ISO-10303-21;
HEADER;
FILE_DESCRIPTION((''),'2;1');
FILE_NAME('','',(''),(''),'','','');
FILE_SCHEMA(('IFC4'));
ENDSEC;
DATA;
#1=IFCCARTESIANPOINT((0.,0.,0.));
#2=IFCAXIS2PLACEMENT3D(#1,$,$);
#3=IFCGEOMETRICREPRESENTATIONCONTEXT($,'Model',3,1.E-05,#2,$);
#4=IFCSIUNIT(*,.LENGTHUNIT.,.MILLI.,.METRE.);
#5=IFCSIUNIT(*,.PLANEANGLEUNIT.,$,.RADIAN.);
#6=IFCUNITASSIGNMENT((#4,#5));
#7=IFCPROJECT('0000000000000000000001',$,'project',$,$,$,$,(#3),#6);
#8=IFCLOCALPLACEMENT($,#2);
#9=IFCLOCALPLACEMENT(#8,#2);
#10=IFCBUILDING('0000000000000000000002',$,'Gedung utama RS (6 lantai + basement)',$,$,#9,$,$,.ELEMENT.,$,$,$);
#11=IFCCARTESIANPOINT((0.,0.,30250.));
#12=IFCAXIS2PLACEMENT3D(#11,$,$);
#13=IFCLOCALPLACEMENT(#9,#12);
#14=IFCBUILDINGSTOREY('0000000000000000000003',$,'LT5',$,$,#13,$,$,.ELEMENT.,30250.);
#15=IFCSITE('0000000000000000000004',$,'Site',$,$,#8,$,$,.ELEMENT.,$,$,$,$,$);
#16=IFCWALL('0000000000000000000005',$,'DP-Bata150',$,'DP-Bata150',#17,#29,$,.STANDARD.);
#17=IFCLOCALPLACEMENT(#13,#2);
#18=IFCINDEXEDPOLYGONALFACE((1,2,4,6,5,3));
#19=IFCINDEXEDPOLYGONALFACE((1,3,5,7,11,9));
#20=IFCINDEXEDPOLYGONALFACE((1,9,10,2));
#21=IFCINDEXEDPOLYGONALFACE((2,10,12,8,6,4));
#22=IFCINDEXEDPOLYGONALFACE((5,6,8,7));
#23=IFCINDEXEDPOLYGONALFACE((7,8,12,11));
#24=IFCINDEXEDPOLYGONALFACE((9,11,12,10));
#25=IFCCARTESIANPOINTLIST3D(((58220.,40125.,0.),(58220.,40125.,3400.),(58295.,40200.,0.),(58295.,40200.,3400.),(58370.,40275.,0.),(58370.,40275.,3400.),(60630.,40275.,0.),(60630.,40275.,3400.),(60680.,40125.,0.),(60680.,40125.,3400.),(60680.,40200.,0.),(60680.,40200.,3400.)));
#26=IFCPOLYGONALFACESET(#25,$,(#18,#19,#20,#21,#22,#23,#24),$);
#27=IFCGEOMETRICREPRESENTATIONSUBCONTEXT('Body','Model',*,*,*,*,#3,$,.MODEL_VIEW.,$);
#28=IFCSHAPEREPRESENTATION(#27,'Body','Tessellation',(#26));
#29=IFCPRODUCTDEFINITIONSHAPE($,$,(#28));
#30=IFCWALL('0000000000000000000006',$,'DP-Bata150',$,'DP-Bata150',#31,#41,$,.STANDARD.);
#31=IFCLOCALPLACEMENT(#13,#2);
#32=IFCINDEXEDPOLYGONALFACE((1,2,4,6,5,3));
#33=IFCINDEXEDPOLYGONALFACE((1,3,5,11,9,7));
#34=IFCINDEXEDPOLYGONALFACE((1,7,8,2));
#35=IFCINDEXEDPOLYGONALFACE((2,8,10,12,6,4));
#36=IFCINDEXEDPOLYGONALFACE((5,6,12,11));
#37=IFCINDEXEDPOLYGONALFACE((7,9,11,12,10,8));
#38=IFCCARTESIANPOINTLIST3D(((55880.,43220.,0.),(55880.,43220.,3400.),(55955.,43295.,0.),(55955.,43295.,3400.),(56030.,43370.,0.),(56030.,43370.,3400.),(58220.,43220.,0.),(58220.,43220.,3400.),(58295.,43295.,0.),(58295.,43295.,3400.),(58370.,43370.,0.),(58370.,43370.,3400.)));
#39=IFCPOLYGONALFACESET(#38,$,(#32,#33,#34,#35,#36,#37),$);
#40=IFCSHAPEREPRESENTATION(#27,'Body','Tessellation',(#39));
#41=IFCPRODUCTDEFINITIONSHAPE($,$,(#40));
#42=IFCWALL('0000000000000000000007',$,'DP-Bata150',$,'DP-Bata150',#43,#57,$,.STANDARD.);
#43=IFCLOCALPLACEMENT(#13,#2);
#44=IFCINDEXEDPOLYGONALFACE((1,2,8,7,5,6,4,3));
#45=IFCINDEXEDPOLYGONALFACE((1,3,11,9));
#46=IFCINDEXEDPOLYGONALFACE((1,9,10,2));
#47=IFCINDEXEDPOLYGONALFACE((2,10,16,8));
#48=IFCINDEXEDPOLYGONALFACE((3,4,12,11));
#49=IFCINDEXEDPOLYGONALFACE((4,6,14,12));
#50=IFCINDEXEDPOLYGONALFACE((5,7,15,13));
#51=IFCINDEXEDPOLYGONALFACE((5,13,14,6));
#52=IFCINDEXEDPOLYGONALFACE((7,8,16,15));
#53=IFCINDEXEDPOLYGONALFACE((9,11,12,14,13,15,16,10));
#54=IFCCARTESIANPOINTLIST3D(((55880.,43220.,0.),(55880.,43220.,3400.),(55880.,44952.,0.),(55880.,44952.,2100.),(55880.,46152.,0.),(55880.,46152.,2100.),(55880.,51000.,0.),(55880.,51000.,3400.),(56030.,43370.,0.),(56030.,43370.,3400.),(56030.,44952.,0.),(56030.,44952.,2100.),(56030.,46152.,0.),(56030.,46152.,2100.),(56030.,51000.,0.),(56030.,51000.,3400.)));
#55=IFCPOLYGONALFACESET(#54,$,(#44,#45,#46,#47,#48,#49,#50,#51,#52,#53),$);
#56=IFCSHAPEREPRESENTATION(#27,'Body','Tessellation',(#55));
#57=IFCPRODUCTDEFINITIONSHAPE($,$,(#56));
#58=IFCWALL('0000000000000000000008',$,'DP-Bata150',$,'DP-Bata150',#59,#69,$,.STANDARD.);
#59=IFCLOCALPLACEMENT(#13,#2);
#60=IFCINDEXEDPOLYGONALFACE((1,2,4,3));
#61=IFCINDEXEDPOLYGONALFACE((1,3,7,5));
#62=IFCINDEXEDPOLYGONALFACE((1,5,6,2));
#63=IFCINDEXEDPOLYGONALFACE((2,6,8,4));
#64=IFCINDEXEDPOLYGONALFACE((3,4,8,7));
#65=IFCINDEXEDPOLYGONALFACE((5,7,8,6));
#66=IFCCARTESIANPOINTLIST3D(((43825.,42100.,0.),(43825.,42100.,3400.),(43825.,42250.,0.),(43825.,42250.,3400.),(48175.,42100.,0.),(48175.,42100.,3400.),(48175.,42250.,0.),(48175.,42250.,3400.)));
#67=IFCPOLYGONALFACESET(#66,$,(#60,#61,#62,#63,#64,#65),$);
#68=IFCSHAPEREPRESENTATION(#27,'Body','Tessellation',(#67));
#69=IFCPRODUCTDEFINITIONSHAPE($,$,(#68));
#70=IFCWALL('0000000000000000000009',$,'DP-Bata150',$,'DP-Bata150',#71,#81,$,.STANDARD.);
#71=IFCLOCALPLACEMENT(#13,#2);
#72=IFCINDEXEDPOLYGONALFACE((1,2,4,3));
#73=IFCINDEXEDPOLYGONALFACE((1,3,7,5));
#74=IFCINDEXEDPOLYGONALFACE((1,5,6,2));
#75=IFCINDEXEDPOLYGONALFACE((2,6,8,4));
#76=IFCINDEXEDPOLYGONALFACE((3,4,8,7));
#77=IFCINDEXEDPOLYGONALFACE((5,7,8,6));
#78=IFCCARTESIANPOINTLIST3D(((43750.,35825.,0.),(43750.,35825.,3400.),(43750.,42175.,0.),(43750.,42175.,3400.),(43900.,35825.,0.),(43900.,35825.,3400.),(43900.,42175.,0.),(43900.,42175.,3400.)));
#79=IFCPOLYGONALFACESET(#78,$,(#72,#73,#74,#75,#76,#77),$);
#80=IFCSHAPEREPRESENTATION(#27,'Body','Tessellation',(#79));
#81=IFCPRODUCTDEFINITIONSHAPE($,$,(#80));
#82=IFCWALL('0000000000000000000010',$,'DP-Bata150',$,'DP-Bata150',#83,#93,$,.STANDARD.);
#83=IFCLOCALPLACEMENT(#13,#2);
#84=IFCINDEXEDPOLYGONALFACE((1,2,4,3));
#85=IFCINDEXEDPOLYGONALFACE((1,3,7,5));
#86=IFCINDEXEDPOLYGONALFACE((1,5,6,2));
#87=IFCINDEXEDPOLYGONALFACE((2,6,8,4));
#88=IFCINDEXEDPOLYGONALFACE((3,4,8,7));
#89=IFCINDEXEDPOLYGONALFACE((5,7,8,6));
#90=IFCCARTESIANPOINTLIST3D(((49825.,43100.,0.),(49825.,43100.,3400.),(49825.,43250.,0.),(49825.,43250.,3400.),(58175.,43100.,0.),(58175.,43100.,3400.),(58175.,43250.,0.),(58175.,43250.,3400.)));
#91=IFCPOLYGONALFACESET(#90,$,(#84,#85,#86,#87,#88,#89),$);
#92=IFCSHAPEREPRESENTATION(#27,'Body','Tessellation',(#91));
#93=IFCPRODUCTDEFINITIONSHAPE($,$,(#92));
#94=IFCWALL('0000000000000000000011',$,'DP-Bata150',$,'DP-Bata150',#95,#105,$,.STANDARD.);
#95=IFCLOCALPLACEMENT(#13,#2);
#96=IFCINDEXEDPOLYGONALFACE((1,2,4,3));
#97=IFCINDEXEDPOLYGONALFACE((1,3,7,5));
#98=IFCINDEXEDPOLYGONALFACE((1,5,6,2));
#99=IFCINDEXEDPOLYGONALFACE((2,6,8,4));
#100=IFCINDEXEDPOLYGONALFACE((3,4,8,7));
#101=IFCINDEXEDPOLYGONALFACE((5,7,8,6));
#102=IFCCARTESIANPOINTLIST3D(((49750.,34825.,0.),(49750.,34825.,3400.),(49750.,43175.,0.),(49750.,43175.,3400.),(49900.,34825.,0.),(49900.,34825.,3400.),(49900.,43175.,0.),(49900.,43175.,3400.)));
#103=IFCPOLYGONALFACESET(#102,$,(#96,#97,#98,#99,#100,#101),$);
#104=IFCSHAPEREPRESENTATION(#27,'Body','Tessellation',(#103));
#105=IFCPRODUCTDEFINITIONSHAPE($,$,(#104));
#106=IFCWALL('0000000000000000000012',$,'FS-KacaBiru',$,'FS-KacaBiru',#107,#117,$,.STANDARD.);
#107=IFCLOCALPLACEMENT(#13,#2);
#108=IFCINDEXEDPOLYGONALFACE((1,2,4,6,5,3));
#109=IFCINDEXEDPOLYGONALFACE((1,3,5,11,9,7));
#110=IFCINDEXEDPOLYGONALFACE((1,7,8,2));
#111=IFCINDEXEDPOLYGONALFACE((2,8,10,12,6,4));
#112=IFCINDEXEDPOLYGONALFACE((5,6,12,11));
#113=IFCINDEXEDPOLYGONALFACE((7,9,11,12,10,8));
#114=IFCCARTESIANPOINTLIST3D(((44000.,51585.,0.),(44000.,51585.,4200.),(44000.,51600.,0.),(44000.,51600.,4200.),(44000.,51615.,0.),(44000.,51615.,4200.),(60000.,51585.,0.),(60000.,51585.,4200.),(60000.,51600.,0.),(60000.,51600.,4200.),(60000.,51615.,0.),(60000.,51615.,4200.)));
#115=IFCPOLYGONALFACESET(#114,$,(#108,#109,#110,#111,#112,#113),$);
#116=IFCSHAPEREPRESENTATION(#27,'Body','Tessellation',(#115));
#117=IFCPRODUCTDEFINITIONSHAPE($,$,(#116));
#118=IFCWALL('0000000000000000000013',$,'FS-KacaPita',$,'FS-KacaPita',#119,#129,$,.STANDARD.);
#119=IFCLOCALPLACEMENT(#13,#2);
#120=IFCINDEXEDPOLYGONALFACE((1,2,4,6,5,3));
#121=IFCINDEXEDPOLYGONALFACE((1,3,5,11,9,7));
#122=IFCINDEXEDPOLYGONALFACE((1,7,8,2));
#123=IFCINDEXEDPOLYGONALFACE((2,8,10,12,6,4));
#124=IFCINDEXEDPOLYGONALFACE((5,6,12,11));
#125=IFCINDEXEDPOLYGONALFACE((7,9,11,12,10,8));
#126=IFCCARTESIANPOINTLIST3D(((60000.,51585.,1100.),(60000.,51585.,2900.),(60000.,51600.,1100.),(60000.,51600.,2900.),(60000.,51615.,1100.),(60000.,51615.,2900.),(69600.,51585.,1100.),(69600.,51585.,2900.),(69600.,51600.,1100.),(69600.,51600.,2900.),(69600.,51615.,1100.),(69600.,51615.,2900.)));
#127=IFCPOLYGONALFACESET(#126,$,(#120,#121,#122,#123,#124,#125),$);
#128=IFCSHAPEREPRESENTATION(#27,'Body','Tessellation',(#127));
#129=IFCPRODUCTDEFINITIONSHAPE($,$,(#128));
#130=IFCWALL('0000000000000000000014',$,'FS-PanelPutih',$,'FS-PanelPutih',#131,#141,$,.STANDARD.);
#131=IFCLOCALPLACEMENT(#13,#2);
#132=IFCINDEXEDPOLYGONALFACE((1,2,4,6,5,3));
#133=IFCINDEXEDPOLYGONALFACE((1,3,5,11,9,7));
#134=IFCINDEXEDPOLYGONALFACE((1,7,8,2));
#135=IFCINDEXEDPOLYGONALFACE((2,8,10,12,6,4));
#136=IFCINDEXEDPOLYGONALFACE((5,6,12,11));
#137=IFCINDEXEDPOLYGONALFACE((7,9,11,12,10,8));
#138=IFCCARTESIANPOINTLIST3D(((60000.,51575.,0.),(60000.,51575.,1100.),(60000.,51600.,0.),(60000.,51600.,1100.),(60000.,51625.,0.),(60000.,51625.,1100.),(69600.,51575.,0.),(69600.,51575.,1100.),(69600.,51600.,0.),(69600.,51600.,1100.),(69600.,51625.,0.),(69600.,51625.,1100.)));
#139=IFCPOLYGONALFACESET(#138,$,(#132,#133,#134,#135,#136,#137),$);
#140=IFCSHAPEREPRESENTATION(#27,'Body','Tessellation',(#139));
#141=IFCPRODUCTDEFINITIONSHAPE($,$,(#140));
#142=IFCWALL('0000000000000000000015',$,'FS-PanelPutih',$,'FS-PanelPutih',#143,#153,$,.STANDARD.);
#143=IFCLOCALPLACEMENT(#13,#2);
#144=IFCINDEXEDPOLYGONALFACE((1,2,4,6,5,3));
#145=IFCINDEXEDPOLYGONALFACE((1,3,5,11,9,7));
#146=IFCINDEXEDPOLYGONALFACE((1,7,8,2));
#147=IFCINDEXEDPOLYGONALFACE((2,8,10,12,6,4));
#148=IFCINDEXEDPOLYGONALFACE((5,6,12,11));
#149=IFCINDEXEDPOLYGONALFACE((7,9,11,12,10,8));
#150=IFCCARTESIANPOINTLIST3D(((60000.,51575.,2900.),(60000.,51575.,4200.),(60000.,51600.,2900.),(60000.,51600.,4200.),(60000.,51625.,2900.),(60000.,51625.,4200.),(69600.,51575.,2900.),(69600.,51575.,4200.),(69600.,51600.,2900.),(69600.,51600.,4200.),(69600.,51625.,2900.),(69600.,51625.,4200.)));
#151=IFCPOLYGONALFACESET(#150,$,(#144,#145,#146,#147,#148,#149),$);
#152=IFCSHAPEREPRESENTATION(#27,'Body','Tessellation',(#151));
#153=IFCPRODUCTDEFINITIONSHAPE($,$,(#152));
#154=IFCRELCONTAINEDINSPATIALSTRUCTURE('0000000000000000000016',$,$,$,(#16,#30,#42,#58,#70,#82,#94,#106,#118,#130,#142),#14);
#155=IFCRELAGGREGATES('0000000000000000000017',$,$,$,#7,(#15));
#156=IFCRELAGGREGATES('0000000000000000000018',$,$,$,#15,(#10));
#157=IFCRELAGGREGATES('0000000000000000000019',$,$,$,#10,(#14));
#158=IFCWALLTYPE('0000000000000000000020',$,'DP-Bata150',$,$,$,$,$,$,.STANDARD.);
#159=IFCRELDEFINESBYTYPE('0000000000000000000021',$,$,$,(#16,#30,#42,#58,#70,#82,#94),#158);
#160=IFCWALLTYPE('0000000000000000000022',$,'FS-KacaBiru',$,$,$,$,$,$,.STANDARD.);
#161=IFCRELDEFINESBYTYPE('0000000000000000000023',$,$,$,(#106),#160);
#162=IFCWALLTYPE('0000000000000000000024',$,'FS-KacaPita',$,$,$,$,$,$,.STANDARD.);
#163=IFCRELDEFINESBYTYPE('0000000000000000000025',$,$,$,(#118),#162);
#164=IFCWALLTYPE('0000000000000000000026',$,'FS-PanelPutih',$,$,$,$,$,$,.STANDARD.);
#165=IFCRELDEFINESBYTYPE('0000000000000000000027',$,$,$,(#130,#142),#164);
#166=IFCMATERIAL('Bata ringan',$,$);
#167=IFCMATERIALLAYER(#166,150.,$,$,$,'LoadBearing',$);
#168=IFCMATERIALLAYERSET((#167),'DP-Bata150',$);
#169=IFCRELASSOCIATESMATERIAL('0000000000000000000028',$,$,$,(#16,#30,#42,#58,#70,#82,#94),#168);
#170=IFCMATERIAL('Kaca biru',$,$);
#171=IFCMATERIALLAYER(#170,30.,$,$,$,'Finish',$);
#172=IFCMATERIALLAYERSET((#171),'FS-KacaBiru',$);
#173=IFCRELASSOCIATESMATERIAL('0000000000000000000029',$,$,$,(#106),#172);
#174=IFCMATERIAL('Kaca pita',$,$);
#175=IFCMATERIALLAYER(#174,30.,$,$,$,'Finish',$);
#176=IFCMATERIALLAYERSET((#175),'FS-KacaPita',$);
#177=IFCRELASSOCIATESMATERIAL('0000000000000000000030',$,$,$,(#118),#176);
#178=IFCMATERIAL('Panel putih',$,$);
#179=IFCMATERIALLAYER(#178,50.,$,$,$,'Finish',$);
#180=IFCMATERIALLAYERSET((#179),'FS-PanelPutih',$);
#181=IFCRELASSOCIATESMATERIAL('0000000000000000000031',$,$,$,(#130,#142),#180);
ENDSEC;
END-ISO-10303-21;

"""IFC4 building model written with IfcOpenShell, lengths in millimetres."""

from ifc_helpers import new_model, si_unit, frame, frame_2d, origin, place, context, subcontext, project, spatial, polyline, rectangle, outline, extrude, material, layer, layer_set, layer_usage, type_object, element, save


model = new_model("IFC4")

# Units and contexts
model_context = context("Model", 3, precision=1e-05, world=origin())
body_context = subcontext(model_context, "Body", "Model", "MODEL_VIEW")
ifc_project = project(units=[si_unit("LENGTHUNIT", "METRE", prefix="MILLI"), si_unit("PLANEANGLEUNIT", "RADIAN")], contexts=[model_context])

# Site, building, storey
site_placement = place(None, origin())
site = spatial("IfcSite", under=ifc_project, at=site_placement, Name="Site", CompositionType="ELEMENT")
building_placement = place(site_placement, origin())
building = spatial("IfcBuilding", under=site, at=building_placement, Name="Gedung utama RS (6 lantai + basement)", CompositionType="ELEMENT")
storey_placement = place(building_placement, frame((0.0, 0.0, 30250.0)))
storey = spatial("IfcBuildingStorey", under=building, at=storey_placement, Name="LT5", CompositionType="ELEMENT", Elevation=30250.0)

# Shared definitions
ifc_material_1 = material(Name="Bata ringan")
ifc_layer_1 = layer(ifc_material_1, 150.0, Category="LoadBearing")
ifc_layer_set_1 = layer_set([ifc_layer_1], Name="DP-Bata150")
ifc_layer_usage_1 = layer_usage(ifc_layer_set_1, "AXIS2", "NEGATIVE", 75.0)
wall_type_1 = type_object("IfcWallType", Name="DP-Bata150", PredefinedType="STANDARD")

# Walls
wall_1_placement = place(storey_placement, frame((60680.0, 40200.0, 0.0), z_axis=(0.0, 0.0, 1.0), x_axis=(-1.0, 0.0, 0.0)))
element("IfcWall", 1, at=wall_1_placement, inside=storey, type_object=wall_type_1, material=ifc_layer_usage_1, Name="DP-Bata150", ObjectType="DP-Bata150", PredefinedType="STANDARD", context=body_context, shape_type="SweptSolid", body=[
    extrude(outline(polyline([(50.0, -75.0), (0.0, 0.0), (0.0, 75.0), (2460.0, 75.0), (2385.0, 0.0), (2310.0, -75.0), (50.0, -75.0)])), origin(), (0.0, 0.0, 1.0), 3400.0),
])
wall_2_placement = place(storey_placement, frame((58295.0, 43295.0, 0.0), z_axis=(0.0, 0.0, 1.0), x_axis=(-1.0, 0.0, 0.0)))
element("IfcWall", 2, at=wall_2_placement, inside=storey, type_object=wall_type_1, material=ifc_layer_usage_1, Name="DP-Bata150", ObjectType="DP-Bata150", PredefinedType="STANDARD", context=body_context, shape_type="SweptSolid", body=[
    extrude(outline(polyline([(-75.0, -75.0), (0.0, 0.0), (75.0, 75.0), (2415.0, 75.0), (2340.0, 0.0), (2265.0, -75.0), (-75.0, -75.0)])), origin(), (0.0, 0.0, 1.0), 3400.0),
])

# Wall, opening
wall_3_placement = place(storey_placement, frame((55955.0, 43295.0, 0.0), z_axis=(0.0, 0.0, 1.0), x_axis=(0.0, 1.0, 0.0)))
wall_3 = element("IfcWall", 3, at=wall_3_placement, inside=storey, type_object=wall_type_1, material=ifc_layer_usage_1, Name="DP-Bata150", ObjectType="DP-Bata150", PredefinedType="STANDARD", context=body_context, shape_type="SweptSolid", body=[
    extrude(outline(polyline([(75.0, -75.0), (0.0, 0.0), (-75.0, 75.0), (7705.0, 75.0), (7705.0, -75.0), (75.0, -75.0)])), origin(), (0.0, 0.0, 1.0), 3400.0),
])
opening_1_placement = place(wall_3_placement, frame((1657.0, 0.0, 0.0), z_axis=(0.0, 0.0, 1.0), x_axis=(1.0, 0.0, 0.0)))
element("IfcOpeningElement", 4, at=opening_1_placement, cuts=wall_3, PredefinedType="OPENING", context=body_context, shape_type="SweptSolid", body=[
    extrude(rectangle(XDim=1200.0, YDim=170.0, at=frame_2d((600.0, 0.0))), origin(), (0.0, 0.0, 1.0), 2100.0),
])

# Walls
wall_4_placement = place(storey_placement, frame((48175.0, 42175.0, 0.0), z_axis=(0.0, 0.0, 1.0), x_axis=(-1.0, 0.0, 0.0)))
element("IfcWall", 5, at=wall_4_placement, inside=storey, type_object=wall_type_1, material=ifc_layer_usage_1, Name="DP-Bata150", ObjectType="DP-Bata150", PredefinedType="STANDARD", context=body_context, shape_type="SweptSolid", body=[
    extrude(outline(polyline([(0.0, -75.0), (0.0, 75.0), (4350.0, 75.0), (4350.0, -75.0), (0.0, -75.0)])), origin(), (0.0, 0.0, 1.0), 3400.0),
])
wall_5_placement = place(storey_placement, frame((43825.0, 42175.0, 0.0), z_axis=(0.0, 0.0, 1.0), x_axis=(0.0, -1.0, 0.0)))
element("IfcWall", 6, at=wall_5_placement, inside=storey, type_object=wall_type_1, material=ifc_layer_usage_1, Name="DP-Bata150", ObjectType="DP-Bata150", PredefinedType="STANDARD", context=body_context, shape_type="SweptSolid", body=[
    extrude(outline(polyline([(0.0, -75.0), (0.0, 75.0), (6350.0, 75.0), (6350.0, -75.0), (0.0, -75.0)])), origin(), (0.0, 0.0, 1.0), 3400.0),
])
for number, where, z_axis, x_axis, name in (
    (7, (58175.0, 43175.0, 0.0), (0.0, 0.0, 1.0), (-1.0, 0.0, 0.0), "DP-Bata150"),
    (8, (49825.0, 43175.0, 0.0), (0.0, 0.0, 1.0), (0.0, -1.0, 0.0), "DP-Bata150"),
):
    element("IfcWall", number, at=place(storey_placement, frame(where, z_axis=z_axis, x_axis=x_axis)), inside=storey, type_object=wall_type_1, material=ifc_layer_usage_1, Name=name, ObjectType="DP-Bata150", PredefinedType="STANDARD", context=body_context, shape_type="SweptSolid", body=[
        extrude(outline(polyline([(0.0, -75.0), (0.0, 75.0), (8350.0, 75.0), (8350.0, -75.0), (0.0, -75.0)])), origin(), (0.0, 0.0, 1.0), 3400.0),
    ])
ifc_material_2 = material(Name="Kaca biru")
ifc_layer_2 = layer(ifc_material_2, 30.0, Category="Finish")
ifc_layer_set_2 = layer_set([ifc_layer_2], Name="FS-KacaBiru")
ifc_layer_usage_2 = layer_usage(ifc_layer_set_2, "AXIS2", "NEGATIVE", 15.0)
wall_type_2 = type_object("IfcWallType", Name="FS-KacaBiru", PredefinedType="STANDARD")
wall_6_placement = place(storey_placement, frame((44000.0, 51600.0, 0.0), z_axis=(0.0, 0.0, 1.0), x_axis=(1.0, 0.0, 0.0)))
element("IfcWall", 9, at=wall_6_placement, inside=storey, type_object=wall_type_2, material=ifc_layer_usage_2, Name="FS-KacaBiru", ObjectType="FS-KacaBiru", PredefinedType="STANDARD", context=body_context, shape_type="SweptSolid", body=[
    extrude(outline(polyline([(0.0, -15.0), (0.0, 0.0), (0.0, 15.0), (16000.0, 15.0), (16000.0, 0.0), (16000.0, -15.0), (0.0, -15.0)])), origin(), (0.0, 0.0, 1.0), 4200.0),
])
ifc_material_3 = material(Name="Kaca pita")
ifc_layer_3 = layer(ifc_material_3, 30.0, Category="Finish")
ifc_layer_set_3 = layer_set([ifc_layer_3], Name="FS-KacaPita")
ifc_layer_usage_3 = layer_usage(ifc_layer_set_3, "AXIS2", "NEGATIVE", 15.0)
wall_type_3 = type_object("IfcWallType", Name="FS-KacaPita", PredefinedType="STANDARD")
wall_7_placement = place(storey_placement, frame((60000.0, 51600.0, 1100.0), z_axis=(0.0, 0.0, 1.0), x_axis=(1.0, 0.0, 0.0)))
element("IfcWall", 10, at=wall_7_placement, inside=storey, type_object=wall_type_3, material=ifc_layer_usage_3, Name="FS-KacaPita", ObjectType="FS-KacaPita", PredefinedType="STANDARD", context=body_context, shape_type="SweptSolid", body=[
    extrude(outline(polyline([(0.0, -15.0), (0.0, 0.0), (0.0, 15.0), (9600.0, 15.0), (9600.0, 0.0), (9600.0, -15.0), (0.0, -15.0)])), origin(), (0.0, 0.0, 1.0), 1800.0),
])
ifc_material_4 = material(Name="Panel putih")
ifc_layer_4 = layer(ifc_material_4, 50.0, Category="Finish")
ifc_layer_set_4 = layer_set([ifc_layer_4], Name="FS-PanelPutih")
ifc_layer_usage_4 = layer_usage(ifc_layer_set_4, "AXIS2", "NEGATIVE", 25.0)
wall_type_4 = type_object("IfcWallType", Name="FS-PanelPutih", PredefinedType="STANDARD")
wall_8_placement = place(storey_placement, frame((60000.0, 51600.0, 0.0), z_axis=(0.0, 0.0, 1.0), x_axis=(1.0, 0.0, 0.0)))
element("IfcWall", 11, at=wall_8_placement, inside=storey, type_object=wall_type_4, material=ifc_layer_usage_4, Name="FS-PanelPutih", ObjectType="FS-PanelPutih", PredefinedType="STANDARD", context=body_context, shape_type="SweptSolid", body=[
    extrude(outline(polyline([(0.0, -25.0), (0.0, 0.0), (0.0, 25.0), (9600.0, 25.0), (9600.0, 0.0), (9600.0, -25.0), (0.0, -25.0)])), origin(), (0.0, 0.0, 1.0), 1100.0),
])
wall_9_placement = place(storey_placement, frame((60000.0, 51600.0, 2900.0), z_axis=(0.0, 0.0, 1.0), x_axis=(1.0, 0.0, 0.0)))
element("IfcWall", 12, at=wall_9_placement, inside=storey, type_object=wall_type_4, material=ifc_layer_usage_4, Name="FS-PanelPutih", ObjectType="FS-PanelPutih", PredefinedType="STANDARD", context=body_context, shape_type="SweptSolid", body=[
    extrude(outline(polyline([(0.0, -25.0), (0.0, 0.0), (0.0, 25.0), (9600.0, 25.0), (9600.0, 0.0), (9600.0, -25.0), (0.0, -25.0)])), origin(), (0.0, 0.0, 1.0), 1300.0),
])

save(model, "model.ifc")
